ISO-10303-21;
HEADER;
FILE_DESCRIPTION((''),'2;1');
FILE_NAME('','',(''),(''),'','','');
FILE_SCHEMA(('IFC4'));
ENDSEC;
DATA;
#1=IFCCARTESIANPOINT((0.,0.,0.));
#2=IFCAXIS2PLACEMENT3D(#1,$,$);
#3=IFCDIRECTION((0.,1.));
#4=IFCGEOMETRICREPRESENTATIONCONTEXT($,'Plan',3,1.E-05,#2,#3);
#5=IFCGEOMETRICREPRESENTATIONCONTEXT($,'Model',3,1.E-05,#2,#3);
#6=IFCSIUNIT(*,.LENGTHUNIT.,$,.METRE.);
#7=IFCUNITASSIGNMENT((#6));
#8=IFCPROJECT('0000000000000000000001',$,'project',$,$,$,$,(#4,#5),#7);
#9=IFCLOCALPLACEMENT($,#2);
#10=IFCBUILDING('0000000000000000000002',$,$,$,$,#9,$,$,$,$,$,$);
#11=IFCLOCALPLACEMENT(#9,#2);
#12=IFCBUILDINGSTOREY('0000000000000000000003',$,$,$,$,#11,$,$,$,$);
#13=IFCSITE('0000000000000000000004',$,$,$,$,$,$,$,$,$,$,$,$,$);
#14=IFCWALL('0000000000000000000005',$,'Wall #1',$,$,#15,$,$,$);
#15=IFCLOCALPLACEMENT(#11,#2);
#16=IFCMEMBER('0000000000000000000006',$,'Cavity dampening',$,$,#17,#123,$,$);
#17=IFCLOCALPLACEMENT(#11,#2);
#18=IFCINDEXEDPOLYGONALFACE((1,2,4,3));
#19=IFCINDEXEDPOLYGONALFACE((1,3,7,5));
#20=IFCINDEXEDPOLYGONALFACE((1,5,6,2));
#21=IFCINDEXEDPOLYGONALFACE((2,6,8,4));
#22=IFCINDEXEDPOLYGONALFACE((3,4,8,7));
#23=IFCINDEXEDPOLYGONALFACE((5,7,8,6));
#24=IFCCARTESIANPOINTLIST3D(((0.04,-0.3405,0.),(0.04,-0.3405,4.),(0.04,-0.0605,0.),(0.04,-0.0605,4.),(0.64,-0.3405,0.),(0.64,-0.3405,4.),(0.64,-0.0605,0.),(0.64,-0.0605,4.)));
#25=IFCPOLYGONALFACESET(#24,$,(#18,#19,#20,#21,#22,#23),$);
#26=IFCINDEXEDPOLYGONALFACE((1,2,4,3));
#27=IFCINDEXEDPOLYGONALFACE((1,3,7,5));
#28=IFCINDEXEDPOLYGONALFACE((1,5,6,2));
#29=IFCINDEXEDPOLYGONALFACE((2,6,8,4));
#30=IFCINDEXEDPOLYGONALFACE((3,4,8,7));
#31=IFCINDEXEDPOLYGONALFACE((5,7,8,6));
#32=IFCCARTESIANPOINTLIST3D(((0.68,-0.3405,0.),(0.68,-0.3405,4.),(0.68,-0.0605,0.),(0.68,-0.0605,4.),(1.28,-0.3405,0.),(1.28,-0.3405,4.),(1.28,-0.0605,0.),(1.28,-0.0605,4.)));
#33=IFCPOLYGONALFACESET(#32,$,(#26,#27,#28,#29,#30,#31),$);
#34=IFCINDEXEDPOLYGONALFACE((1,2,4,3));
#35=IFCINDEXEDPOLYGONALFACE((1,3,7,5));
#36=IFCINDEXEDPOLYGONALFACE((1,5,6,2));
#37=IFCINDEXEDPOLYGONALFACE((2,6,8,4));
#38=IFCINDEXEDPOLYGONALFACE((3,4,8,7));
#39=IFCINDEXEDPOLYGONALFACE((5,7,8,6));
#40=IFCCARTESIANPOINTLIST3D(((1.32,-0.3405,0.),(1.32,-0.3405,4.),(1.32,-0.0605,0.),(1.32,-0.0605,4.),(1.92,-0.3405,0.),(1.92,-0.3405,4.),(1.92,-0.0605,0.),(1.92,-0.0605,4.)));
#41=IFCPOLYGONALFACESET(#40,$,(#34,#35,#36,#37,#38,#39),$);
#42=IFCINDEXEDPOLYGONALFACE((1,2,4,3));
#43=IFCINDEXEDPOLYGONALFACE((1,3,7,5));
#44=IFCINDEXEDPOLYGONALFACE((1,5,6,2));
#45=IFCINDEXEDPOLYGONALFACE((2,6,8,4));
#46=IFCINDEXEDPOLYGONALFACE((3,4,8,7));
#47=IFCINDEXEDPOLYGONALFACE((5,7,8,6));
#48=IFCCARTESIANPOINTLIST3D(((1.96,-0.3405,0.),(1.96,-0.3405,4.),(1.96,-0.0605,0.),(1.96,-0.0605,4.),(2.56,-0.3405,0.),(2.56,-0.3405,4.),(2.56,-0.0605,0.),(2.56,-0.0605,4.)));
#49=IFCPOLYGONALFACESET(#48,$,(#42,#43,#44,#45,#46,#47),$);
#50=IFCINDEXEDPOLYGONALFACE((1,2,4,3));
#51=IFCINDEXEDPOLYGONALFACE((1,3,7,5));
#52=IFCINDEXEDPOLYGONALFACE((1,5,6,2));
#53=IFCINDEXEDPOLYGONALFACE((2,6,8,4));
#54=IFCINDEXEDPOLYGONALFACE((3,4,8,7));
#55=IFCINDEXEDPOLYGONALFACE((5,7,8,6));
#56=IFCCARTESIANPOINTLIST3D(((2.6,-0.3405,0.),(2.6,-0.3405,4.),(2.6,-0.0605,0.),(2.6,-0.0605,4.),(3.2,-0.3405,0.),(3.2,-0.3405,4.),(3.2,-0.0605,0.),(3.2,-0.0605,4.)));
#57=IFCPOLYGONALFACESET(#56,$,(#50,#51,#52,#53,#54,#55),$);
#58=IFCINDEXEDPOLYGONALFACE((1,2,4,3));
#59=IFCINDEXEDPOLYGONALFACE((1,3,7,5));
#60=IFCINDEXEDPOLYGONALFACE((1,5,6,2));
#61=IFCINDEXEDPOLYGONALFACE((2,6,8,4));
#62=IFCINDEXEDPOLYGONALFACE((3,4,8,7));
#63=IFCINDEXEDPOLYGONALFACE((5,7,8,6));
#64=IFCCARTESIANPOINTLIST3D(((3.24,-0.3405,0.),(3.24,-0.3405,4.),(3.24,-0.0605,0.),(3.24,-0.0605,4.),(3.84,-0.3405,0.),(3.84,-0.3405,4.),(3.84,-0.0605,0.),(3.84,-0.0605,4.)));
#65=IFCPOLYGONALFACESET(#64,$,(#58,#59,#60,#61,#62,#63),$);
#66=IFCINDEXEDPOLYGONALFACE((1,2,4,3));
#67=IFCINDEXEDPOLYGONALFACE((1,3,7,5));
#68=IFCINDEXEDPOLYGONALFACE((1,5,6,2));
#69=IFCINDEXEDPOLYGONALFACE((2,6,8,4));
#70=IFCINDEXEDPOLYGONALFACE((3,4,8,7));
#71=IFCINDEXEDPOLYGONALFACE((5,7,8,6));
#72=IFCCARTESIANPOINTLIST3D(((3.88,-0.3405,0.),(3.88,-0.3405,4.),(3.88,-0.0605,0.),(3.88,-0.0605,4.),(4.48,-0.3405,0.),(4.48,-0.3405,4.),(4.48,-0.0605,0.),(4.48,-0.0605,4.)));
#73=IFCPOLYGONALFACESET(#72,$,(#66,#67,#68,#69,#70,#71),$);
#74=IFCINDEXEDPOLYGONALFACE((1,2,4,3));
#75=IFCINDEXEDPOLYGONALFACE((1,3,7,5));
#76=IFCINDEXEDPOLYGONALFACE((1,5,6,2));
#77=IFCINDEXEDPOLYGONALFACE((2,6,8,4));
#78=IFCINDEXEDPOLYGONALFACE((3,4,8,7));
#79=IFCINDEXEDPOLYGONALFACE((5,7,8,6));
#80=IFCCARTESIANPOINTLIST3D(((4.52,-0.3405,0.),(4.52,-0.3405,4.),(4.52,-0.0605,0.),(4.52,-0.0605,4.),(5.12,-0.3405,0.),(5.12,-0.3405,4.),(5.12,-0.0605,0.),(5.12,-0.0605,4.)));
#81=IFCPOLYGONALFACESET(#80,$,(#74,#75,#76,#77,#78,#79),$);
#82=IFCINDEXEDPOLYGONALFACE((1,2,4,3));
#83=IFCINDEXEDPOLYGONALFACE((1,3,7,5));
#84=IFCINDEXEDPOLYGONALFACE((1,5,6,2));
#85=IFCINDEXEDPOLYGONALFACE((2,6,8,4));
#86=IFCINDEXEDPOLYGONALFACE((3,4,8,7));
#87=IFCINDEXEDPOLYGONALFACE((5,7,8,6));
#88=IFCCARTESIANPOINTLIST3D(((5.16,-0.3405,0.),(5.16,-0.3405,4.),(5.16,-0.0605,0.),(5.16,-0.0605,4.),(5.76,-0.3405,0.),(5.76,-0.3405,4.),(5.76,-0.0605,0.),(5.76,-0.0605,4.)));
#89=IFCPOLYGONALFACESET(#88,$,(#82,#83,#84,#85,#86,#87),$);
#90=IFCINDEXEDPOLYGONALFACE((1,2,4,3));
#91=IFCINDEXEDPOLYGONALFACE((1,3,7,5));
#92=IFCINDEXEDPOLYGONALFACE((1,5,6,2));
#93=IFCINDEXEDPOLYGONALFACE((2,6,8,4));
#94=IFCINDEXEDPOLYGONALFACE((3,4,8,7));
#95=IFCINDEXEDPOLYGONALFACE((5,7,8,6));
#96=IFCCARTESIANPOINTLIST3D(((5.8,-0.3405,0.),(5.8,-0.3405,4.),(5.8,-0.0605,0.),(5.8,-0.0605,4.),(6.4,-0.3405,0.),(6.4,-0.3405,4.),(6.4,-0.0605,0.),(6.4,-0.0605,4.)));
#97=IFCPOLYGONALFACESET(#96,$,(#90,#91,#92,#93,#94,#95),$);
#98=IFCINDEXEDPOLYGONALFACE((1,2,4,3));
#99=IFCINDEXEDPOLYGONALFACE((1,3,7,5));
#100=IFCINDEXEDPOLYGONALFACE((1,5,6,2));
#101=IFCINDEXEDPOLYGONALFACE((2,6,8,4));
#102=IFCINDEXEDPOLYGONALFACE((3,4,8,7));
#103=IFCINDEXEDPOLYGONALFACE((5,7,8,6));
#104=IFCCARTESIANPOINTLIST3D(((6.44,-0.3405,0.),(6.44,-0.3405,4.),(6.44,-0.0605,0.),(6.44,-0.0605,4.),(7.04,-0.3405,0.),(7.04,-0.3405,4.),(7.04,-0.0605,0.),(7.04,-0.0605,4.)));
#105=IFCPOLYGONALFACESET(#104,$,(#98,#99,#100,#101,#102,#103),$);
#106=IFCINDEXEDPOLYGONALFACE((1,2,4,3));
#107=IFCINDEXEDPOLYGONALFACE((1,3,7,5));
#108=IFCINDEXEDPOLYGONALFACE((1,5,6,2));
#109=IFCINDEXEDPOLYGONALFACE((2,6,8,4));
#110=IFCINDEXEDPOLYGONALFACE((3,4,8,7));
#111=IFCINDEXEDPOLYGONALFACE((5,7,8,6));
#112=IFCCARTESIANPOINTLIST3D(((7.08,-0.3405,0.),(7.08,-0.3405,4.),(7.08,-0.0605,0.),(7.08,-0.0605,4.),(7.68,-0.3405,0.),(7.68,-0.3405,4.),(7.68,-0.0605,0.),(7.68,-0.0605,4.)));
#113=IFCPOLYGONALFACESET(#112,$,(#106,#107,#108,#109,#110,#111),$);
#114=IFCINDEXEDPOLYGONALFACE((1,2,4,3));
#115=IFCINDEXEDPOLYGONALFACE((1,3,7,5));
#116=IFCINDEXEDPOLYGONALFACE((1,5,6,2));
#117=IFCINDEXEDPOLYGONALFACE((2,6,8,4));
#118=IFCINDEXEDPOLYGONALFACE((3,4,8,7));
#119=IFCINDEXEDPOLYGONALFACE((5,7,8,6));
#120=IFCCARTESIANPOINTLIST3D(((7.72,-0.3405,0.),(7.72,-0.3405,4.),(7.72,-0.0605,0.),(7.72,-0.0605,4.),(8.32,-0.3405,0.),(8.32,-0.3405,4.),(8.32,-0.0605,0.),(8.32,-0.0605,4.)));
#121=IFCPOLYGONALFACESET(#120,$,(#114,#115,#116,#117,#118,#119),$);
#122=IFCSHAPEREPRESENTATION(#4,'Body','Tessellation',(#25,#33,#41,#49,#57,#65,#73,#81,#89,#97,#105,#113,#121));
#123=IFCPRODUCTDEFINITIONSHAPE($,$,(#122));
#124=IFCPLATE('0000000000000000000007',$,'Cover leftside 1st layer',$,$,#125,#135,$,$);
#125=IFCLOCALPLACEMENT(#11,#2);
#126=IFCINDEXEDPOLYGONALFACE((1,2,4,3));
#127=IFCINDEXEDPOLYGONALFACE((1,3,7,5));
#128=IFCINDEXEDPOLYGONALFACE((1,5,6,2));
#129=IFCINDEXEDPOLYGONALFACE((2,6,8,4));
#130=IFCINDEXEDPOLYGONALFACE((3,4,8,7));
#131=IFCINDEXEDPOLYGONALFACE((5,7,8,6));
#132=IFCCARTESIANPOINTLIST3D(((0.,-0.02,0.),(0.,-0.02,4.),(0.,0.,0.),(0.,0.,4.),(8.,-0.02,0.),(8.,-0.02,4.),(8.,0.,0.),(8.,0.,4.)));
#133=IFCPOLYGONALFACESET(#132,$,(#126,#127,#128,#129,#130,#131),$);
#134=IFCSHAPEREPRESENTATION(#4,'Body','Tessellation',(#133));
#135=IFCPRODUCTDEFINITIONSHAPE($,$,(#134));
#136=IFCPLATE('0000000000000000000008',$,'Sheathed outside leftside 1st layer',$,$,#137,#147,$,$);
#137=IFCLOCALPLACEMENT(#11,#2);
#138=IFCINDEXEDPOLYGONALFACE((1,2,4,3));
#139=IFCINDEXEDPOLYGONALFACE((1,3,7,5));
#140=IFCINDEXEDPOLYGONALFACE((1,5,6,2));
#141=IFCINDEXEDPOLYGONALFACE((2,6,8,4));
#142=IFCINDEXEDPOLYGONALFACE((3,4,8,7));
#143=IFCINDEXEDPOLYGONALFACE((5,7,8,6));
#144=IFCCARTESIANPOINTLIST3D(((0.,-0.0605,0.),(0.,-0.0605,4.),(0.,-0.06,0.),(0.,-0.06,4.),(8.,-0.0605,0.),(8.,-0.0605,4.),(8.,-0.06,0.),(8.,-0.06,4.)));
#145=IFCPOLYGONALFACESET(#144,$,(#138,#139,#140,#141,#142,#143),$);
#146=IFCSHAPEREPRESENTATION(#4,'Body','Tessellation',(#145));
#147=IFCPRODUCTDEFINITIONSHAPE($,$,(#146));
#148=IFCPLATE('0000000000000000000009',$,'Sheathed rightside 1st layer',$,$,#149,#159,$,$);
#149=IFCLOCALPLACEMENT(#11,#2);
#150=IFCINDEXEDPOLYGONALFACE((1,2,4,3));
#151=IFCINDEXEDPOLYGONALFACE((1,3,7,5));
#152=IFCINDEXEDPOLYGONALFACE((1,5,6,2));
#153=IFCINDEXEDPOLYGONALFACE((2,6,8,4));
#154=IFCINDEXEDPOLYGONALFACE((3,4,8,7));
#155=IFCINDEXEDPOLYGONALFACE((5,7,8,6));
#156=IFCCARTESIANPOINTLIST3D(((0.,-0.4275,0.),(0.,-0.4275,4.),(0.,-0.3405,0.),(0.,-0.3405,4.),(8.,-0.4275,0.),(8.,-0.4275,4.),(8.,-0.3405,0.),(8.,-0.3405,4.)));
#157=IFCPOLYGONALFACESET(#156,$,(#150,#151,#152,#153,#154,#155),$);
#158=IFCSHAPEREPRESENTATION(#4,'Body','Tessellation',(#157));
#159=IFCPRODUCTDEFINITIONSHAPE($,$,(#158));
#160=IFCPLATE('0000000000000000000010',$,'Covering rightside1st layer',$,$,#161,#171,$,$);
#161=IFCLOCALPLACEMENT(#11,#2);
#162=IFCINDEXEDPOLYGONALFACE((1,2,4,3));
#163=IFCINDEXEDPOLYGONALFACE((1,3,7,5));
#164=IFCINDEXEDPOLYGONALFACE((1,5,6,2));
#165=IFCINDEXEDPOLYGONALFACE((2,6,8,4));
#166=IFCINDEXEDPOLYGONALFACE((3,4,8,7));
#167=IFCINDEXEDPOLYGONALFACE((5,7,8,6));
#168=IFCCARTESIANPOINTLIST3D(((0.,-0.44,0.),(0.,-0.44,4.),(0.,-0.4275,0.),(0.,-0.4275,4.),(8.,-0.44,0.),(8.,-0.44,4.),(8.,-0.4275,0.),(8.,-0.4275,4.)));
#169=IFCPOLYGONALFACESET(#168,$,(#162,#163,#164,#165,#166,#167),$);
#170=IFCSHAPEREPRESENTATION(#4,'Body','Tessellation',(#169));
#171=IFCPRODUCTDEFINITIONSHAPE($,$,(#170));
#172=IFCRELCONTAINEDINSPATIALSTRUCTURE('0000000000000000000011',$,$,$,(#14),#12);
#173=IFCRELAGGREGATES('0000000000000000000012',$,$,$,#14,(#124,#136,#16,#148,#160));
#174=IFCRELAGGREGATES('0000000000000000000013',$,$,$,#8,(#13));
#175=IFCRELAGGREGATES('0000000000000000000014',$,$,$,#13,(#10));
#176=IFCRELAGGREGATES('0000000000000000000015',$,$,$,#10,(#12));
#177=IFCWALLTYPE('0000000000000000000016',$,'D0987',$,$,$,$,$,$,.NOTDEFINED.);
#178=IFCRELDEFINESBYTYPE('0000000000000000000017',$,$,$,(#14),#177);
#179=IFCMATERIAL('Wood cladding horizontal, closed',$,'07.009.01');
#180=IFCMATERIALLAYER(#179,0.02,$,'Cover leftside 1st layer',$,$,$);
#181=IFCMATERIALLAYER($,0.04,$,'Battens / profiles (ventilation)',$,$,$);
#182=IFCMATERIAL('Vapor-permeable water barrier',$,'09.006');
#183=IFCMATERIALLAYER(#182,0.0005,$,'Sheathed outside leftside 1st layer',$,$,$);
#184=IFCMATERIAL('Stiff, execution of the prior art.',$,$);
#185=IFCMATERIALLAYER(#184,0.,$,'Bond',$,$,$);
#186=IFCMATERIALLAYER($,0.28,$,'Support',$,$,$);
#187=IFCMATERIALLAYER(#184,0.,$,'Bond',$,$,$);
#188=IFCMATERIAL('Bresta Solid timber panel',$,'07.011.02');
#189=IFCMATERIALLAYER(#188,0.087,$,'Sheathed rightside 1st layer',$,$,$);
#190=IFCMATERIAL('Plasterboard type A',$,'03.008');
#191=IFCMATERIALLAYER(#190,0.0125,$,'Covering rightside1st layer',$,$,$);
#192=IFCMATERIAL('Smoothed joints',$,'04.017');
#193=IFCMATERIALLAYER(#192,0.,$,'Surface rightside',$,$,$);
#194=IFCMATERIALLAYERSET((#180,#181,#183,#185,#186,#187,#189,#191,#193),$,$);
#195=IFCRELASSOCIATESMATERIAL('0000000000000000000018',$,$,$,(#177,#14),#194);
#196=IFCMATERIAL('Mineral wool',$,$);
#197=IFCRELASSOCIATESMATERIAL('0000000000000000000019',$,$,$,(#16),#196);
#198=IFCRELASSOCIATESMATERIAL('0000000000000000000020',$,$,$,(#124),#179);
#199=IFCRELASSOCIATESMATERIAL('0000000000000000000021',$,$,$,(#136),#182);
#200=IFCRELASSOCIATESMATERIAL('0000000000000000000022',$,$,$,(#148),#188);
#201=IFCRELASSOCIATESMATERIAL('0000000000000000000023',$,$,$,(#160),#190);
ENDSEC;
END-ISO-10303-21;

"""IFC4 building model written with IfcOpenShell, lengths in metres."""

from ifc_helpers import new_model, si_unit, direction, frame, frame_2d, origin, origin_with_axes, place, context, project, spatial, rectangle, extrude, material, layer, layer_set, type_object, element, aggregate, save


model = new_model("IFC4")

# Units and contexts
plan_context = context("Plan", 3, precision=1e-05, world=origin(), true_north=direction((0.0, 1.0)))
model_context = context("Model", 3, precision=1e-05, world=origin(), true_north=direction((0.0, 1.0)))
ifc_project = project(units=[si_unit("LENGTHUNIT", "METRE")], contexts=[plan_context, model_context])

# Site, building, storey
site = spatial("IfcSite", under=ifc_project)
building_placement = place(None, origin())
building = spatial("IfcBuilding", under=site, at=building_placement)
storey_placement = place(building_placement, origin())
storey = spatial("IfcBuildingStorey", under=building, at=storey_placement)

# Wall, member, plates
ifc_material_1 = material(Name="Wood cladding horizontal, closed", Category="07.009.01")
ifc_layer_1 = layer(ifc_material_1, 0.02, Name="Cover leftside 1st layer")
ifc_layer_2 = layer(None, 0.04, Name="Battens / profiles (ventilation)")
ifc_material_2 = material(Name="Vapor-permeable water barrier", Category="09.006")
ifc_layer_3 = layer(ifc_material_2, 0.0005, Name="Sheathed outside leftside 1st layer")
ifc_material_3 = material(Name="Stiff, execution of the prior art.")
ifc_layer_4 = layer(ifc_material_3, 0.0, Name="Bond")
ifc_layer_5 = layer(None, 0.28, Name="Support")
ifc_layer_6 = layer(ifc_material_3, 0.0, Name="Bond")
ifc_material_4 = material(Name="Bresta Solid timber panel", Category="07.011.02")
ifc_layer_7 = layer(ifc_material_4, 0.087, Name="Sheathed rightside 1st layer")
ifc_material_5 = material(Name="Plasterboard type A", Category="03.008")
ifc_layer_8 = layer(ifc_material_5, 0.0125, Name="Covering rightside1st layer")
ifc_material_6 = material(Name="Smoothed joints", Category="04.017")
ifc_layer_9 = layer(ifc_material_6, 0.0, Name="Surface rightside")
ifc_layer_set = layer_set([ifc_layer_1, ifc_layer_2, ifc_layer_3, ifc_layer_4, ifc_layer_5, ifc_layer_6, ifc_layer_7, ifc_layer_8, ifc_layer_9])
wall_type = type_object("IfcWallType", Name="D0987", PredefinedType="NOTDEFINED", material=ifc_layer_set)
wall_placement = place(None, frame((0.0, 0.0, 0.0), z_axis=(0.0, -1.0, 0.0), x_axis=(1.0, 0.0, 0.0)))
wall = element("IfcWall", 1, at=wall_placement, inside=storey, type_object=wall_type, material=ifc_layer_set, Name="Wall #1")
ifc_material_7 = material(Name="Mineral wool")
member_1_placement = place(wall_placement, origin())
member_1 = element("IfcMember", 2, at=member_1_placement, material=ifc_material_7, Name="Cavity dampening", context=plan_context, shape_type="SweptSolid", body=[
    extrude(rectangle(XDim=0.6, YDim=0.28, at=frame_2d((0.3, 0.14), x_axis=(1.0, 0.0))), frame((0.04, 4.0, 0.0605), z_axis=(0.0, -1.0, 0.0), x_axis=(1.0, 0.0, 0.0)), (0.0, 0.0, 1.0), 4.0),
    extrude(rectangle(XDim=0.6, YDim=0.28, at=frame_2d((0.3, 0.14), x_axis=(1.0, 0.0))), frame((0.68, 4.0, 0.0605), z_axis=(0.0, -1.0, 0.0), x_axis=(1.0, 0.0, 0.0)), (0.0, 0.0, 1.0), 4.0),
    extrude(rectangle(XDim=0.6, YDim=0.28, at=frame_2d((0.3, 0.14), x_axis=(1.0, 0.0))), frame((1.32, 4.0, 0.0605), z_axis=(0.0, -1.0, 0.0), x_axis=(1.0, 0.0, 0.0)), (0.0, 0.0, 1.0), 4.0),
    extrude(rectangle(XDim=0.6, YDim=0.28, at=frame_2d((0.3, 0.14), x_axis=(1.0, 0.0))), frame((1.96, 4.0, 0.0605), z_axis=(0.0, -1.0, 0.0), x_axis=(1.0, 0.0, 0.0)), (0.0, 0.0, 1.0), 4.0),
    extrude(rectangle(XDim=0.6, YDim=0.28, at=frame_2d((0.3, 0.14), x_axis=(1.0, 0.0))), frame((2.6, 4.0, 0.0605), z_axis=(0.0, -1.0, 0.0), x_axis=(1.0, 0.0, 0.0)), (0.0, 0.0, 1.0), 4.0),
    extrude(rectangle(XDim=0.6, YDim=0.28, at=frame_2d((0.3, 0.14), x_axis=(1.0, 0.0))), frame((3.24, 4.0, 0.0605), z_axis=(0.0, -1.0, 0.0), x_axis=(1.0, 0.0, 0.0)), (0.0, 0.0, 1.0), 4.0),
    extrude(rectangle(XDim=0.6, YDim=0.28, at=frame_2d((0.3, 0.14), x_axis=(1.0, 0.0))), frame((3.88, 4.0, 0.0605), z_axis=(0.0, -1.0, 0.0), x_axis=(1.0, 0.0, 0.0)), (0.0, 0.0, 1.0), 4.0),
    extrude(rectangle(XDim=0.6, YDim=0.28, at=frame_2d((0.3, 0.14), x_axis=(1.0, 0.0))), frame((4.52, 4.0, 0.0605), z_axis=(0.0, -1.0, 0.0), x_axis=(1.0, 0.0, 0.0)), (0.0, 0.0, 1.0), 4.0),
    extrude(rectangle(XDim=0.6, YDim=0.28, at=frame_2d((0.3, 0.14), x_axis=(1.0, 0.0))), frame((5.16, 4.0, 0.0605), z_axis=(0.0, -1.0, 0.0), x_axis=(1.0, 0.0, 0.0)), (0.0, 0.0, 1.0), 4.0),
    extrude(rectangle(XDim=0.6, YDim=0.28, at=frame_2d((0.3, 0.14), x_axis=(1.0, 0.0))), frame((5.8, 4.0, 0.0605), z_axis=(0.0, -1.0, 0.0), x_axis=(1.0, 0.0, 0.0)), (0.0, 0.0, 1.0), 4.0),
    extrude(rectangle(XDim=0.6, YDim=0.28, at=frame_2d((0.3, 0.14), x_axis=(1.0, 0.0))), frame((6.44, 4.0, 0.0605), z_axis=(0.0, -1.0, 0.0), x_axis=(1.0, 0.0, 0.0)), (0.0, 0.0, 1.0), 4.0),
    extrude(rectangle(XDim=0.6, YDim=0.28, at=frame_2d((0.3, 0.14), x_axis=(1.0, 0.0))), frame((7.08, 4.0, 0.0605), z_axis=(0.0, -1.0, 0.0), x_axis=(1.0, 0.0, 0.0)), (0.0, 0.0, 1.0), 4.0),
    extrude(rectangle(XDim=0.6, YDim=0.28, at=frame_2d((0.3, 0.14), x_axis=(1.0, 0.0))), frame((7.72, 4.0, 0.0605), z_axis=(0.0, -1.0, 0.0), x_axis=(1.0, 0.0, 0.0)), (0.0, 0.0, 1.0), 4.0),
])
plate_1_placement = place(wall_placement, origin())
plate_1 = element("IfcPlate", 3, at=plate_1_placement, material=ifc_material_1, Name="Cover leftside 1st layer", context=plan_context, shape_type="SweptSolid", body=[
    extrude(rectangle(XDim=8.0, YDim=4.0, at=frame_2d((4.0, 2.0), x_axis=(1.0, 0.0))), origin_with_axes(), (0.0, 0.0, 1.0), 0.02),
])
plate_2_placement = place(wall_placement, origin())
plate_2 = element("IfcPlate", 4, at=plate_2_placement, material=ifc_material_2, Name="Sheathed outside leftside 1st layer", context=plan_context, shape_type="SweptSolid", body=[
    extrude(rectangle(XDim=8.0, YDim=4.0, at=frame_2d((4.0, 2.0), x_axis=(1.0, 0.0))), frame((0.0, 0.0, 0.06), z_axis=(0.0, 0.0, 1.0), x_axis=(1.0, 0.0, 0.0)), (0.0, 0.0, 1.0), 0.0005),
])
plate_3_placement = place(wall_placement, origin())
plate_3 = element("IfcPlate", 5, at=plate_3_placement, material=ifc_material_4, Name="Sheathed rightside 1st layer", context=plan_context, shape_type="SweptSolid", body=[
    extrude(rectangle(XDim=8.0, YDim=4.0, at=frame_2d((4.0, 2.0), x_axis=(1.0, 0.0))), frame((0.0, 0.0, 0.3405), z_axis=(0.0, 0.0, 1.0), x_axis=(1.0, 0.0, 0.0)), (0.0, 0.0, 1.0), 0.087),
])
plate_4_placement = place(wall_placement, origin())
plate_4 = element("IfcPlate", 6, at=plate_4_placement, material=ifc_material_5, Name="Covering rightside1st layer", context=plan_context, shape_type="SweptSolid", body=[
    extrude(rectangle(XDim=8.0, YDim=4.0, at=frame_2d((4.0, 2.0), x_axis=(1.0, 0.0))), frame((0.0, 0.0, 0.4275), z_axis=(0.0, 0.0, 1.0), x_axis=(1.0, 0.0, 0.0)), (0.0, 0.0, 1.0), 0.0125),
])
aggregate(wall, [plate_1, plate_2, member_1, plate_3, plate_4])

save(model, "model.ifc")
